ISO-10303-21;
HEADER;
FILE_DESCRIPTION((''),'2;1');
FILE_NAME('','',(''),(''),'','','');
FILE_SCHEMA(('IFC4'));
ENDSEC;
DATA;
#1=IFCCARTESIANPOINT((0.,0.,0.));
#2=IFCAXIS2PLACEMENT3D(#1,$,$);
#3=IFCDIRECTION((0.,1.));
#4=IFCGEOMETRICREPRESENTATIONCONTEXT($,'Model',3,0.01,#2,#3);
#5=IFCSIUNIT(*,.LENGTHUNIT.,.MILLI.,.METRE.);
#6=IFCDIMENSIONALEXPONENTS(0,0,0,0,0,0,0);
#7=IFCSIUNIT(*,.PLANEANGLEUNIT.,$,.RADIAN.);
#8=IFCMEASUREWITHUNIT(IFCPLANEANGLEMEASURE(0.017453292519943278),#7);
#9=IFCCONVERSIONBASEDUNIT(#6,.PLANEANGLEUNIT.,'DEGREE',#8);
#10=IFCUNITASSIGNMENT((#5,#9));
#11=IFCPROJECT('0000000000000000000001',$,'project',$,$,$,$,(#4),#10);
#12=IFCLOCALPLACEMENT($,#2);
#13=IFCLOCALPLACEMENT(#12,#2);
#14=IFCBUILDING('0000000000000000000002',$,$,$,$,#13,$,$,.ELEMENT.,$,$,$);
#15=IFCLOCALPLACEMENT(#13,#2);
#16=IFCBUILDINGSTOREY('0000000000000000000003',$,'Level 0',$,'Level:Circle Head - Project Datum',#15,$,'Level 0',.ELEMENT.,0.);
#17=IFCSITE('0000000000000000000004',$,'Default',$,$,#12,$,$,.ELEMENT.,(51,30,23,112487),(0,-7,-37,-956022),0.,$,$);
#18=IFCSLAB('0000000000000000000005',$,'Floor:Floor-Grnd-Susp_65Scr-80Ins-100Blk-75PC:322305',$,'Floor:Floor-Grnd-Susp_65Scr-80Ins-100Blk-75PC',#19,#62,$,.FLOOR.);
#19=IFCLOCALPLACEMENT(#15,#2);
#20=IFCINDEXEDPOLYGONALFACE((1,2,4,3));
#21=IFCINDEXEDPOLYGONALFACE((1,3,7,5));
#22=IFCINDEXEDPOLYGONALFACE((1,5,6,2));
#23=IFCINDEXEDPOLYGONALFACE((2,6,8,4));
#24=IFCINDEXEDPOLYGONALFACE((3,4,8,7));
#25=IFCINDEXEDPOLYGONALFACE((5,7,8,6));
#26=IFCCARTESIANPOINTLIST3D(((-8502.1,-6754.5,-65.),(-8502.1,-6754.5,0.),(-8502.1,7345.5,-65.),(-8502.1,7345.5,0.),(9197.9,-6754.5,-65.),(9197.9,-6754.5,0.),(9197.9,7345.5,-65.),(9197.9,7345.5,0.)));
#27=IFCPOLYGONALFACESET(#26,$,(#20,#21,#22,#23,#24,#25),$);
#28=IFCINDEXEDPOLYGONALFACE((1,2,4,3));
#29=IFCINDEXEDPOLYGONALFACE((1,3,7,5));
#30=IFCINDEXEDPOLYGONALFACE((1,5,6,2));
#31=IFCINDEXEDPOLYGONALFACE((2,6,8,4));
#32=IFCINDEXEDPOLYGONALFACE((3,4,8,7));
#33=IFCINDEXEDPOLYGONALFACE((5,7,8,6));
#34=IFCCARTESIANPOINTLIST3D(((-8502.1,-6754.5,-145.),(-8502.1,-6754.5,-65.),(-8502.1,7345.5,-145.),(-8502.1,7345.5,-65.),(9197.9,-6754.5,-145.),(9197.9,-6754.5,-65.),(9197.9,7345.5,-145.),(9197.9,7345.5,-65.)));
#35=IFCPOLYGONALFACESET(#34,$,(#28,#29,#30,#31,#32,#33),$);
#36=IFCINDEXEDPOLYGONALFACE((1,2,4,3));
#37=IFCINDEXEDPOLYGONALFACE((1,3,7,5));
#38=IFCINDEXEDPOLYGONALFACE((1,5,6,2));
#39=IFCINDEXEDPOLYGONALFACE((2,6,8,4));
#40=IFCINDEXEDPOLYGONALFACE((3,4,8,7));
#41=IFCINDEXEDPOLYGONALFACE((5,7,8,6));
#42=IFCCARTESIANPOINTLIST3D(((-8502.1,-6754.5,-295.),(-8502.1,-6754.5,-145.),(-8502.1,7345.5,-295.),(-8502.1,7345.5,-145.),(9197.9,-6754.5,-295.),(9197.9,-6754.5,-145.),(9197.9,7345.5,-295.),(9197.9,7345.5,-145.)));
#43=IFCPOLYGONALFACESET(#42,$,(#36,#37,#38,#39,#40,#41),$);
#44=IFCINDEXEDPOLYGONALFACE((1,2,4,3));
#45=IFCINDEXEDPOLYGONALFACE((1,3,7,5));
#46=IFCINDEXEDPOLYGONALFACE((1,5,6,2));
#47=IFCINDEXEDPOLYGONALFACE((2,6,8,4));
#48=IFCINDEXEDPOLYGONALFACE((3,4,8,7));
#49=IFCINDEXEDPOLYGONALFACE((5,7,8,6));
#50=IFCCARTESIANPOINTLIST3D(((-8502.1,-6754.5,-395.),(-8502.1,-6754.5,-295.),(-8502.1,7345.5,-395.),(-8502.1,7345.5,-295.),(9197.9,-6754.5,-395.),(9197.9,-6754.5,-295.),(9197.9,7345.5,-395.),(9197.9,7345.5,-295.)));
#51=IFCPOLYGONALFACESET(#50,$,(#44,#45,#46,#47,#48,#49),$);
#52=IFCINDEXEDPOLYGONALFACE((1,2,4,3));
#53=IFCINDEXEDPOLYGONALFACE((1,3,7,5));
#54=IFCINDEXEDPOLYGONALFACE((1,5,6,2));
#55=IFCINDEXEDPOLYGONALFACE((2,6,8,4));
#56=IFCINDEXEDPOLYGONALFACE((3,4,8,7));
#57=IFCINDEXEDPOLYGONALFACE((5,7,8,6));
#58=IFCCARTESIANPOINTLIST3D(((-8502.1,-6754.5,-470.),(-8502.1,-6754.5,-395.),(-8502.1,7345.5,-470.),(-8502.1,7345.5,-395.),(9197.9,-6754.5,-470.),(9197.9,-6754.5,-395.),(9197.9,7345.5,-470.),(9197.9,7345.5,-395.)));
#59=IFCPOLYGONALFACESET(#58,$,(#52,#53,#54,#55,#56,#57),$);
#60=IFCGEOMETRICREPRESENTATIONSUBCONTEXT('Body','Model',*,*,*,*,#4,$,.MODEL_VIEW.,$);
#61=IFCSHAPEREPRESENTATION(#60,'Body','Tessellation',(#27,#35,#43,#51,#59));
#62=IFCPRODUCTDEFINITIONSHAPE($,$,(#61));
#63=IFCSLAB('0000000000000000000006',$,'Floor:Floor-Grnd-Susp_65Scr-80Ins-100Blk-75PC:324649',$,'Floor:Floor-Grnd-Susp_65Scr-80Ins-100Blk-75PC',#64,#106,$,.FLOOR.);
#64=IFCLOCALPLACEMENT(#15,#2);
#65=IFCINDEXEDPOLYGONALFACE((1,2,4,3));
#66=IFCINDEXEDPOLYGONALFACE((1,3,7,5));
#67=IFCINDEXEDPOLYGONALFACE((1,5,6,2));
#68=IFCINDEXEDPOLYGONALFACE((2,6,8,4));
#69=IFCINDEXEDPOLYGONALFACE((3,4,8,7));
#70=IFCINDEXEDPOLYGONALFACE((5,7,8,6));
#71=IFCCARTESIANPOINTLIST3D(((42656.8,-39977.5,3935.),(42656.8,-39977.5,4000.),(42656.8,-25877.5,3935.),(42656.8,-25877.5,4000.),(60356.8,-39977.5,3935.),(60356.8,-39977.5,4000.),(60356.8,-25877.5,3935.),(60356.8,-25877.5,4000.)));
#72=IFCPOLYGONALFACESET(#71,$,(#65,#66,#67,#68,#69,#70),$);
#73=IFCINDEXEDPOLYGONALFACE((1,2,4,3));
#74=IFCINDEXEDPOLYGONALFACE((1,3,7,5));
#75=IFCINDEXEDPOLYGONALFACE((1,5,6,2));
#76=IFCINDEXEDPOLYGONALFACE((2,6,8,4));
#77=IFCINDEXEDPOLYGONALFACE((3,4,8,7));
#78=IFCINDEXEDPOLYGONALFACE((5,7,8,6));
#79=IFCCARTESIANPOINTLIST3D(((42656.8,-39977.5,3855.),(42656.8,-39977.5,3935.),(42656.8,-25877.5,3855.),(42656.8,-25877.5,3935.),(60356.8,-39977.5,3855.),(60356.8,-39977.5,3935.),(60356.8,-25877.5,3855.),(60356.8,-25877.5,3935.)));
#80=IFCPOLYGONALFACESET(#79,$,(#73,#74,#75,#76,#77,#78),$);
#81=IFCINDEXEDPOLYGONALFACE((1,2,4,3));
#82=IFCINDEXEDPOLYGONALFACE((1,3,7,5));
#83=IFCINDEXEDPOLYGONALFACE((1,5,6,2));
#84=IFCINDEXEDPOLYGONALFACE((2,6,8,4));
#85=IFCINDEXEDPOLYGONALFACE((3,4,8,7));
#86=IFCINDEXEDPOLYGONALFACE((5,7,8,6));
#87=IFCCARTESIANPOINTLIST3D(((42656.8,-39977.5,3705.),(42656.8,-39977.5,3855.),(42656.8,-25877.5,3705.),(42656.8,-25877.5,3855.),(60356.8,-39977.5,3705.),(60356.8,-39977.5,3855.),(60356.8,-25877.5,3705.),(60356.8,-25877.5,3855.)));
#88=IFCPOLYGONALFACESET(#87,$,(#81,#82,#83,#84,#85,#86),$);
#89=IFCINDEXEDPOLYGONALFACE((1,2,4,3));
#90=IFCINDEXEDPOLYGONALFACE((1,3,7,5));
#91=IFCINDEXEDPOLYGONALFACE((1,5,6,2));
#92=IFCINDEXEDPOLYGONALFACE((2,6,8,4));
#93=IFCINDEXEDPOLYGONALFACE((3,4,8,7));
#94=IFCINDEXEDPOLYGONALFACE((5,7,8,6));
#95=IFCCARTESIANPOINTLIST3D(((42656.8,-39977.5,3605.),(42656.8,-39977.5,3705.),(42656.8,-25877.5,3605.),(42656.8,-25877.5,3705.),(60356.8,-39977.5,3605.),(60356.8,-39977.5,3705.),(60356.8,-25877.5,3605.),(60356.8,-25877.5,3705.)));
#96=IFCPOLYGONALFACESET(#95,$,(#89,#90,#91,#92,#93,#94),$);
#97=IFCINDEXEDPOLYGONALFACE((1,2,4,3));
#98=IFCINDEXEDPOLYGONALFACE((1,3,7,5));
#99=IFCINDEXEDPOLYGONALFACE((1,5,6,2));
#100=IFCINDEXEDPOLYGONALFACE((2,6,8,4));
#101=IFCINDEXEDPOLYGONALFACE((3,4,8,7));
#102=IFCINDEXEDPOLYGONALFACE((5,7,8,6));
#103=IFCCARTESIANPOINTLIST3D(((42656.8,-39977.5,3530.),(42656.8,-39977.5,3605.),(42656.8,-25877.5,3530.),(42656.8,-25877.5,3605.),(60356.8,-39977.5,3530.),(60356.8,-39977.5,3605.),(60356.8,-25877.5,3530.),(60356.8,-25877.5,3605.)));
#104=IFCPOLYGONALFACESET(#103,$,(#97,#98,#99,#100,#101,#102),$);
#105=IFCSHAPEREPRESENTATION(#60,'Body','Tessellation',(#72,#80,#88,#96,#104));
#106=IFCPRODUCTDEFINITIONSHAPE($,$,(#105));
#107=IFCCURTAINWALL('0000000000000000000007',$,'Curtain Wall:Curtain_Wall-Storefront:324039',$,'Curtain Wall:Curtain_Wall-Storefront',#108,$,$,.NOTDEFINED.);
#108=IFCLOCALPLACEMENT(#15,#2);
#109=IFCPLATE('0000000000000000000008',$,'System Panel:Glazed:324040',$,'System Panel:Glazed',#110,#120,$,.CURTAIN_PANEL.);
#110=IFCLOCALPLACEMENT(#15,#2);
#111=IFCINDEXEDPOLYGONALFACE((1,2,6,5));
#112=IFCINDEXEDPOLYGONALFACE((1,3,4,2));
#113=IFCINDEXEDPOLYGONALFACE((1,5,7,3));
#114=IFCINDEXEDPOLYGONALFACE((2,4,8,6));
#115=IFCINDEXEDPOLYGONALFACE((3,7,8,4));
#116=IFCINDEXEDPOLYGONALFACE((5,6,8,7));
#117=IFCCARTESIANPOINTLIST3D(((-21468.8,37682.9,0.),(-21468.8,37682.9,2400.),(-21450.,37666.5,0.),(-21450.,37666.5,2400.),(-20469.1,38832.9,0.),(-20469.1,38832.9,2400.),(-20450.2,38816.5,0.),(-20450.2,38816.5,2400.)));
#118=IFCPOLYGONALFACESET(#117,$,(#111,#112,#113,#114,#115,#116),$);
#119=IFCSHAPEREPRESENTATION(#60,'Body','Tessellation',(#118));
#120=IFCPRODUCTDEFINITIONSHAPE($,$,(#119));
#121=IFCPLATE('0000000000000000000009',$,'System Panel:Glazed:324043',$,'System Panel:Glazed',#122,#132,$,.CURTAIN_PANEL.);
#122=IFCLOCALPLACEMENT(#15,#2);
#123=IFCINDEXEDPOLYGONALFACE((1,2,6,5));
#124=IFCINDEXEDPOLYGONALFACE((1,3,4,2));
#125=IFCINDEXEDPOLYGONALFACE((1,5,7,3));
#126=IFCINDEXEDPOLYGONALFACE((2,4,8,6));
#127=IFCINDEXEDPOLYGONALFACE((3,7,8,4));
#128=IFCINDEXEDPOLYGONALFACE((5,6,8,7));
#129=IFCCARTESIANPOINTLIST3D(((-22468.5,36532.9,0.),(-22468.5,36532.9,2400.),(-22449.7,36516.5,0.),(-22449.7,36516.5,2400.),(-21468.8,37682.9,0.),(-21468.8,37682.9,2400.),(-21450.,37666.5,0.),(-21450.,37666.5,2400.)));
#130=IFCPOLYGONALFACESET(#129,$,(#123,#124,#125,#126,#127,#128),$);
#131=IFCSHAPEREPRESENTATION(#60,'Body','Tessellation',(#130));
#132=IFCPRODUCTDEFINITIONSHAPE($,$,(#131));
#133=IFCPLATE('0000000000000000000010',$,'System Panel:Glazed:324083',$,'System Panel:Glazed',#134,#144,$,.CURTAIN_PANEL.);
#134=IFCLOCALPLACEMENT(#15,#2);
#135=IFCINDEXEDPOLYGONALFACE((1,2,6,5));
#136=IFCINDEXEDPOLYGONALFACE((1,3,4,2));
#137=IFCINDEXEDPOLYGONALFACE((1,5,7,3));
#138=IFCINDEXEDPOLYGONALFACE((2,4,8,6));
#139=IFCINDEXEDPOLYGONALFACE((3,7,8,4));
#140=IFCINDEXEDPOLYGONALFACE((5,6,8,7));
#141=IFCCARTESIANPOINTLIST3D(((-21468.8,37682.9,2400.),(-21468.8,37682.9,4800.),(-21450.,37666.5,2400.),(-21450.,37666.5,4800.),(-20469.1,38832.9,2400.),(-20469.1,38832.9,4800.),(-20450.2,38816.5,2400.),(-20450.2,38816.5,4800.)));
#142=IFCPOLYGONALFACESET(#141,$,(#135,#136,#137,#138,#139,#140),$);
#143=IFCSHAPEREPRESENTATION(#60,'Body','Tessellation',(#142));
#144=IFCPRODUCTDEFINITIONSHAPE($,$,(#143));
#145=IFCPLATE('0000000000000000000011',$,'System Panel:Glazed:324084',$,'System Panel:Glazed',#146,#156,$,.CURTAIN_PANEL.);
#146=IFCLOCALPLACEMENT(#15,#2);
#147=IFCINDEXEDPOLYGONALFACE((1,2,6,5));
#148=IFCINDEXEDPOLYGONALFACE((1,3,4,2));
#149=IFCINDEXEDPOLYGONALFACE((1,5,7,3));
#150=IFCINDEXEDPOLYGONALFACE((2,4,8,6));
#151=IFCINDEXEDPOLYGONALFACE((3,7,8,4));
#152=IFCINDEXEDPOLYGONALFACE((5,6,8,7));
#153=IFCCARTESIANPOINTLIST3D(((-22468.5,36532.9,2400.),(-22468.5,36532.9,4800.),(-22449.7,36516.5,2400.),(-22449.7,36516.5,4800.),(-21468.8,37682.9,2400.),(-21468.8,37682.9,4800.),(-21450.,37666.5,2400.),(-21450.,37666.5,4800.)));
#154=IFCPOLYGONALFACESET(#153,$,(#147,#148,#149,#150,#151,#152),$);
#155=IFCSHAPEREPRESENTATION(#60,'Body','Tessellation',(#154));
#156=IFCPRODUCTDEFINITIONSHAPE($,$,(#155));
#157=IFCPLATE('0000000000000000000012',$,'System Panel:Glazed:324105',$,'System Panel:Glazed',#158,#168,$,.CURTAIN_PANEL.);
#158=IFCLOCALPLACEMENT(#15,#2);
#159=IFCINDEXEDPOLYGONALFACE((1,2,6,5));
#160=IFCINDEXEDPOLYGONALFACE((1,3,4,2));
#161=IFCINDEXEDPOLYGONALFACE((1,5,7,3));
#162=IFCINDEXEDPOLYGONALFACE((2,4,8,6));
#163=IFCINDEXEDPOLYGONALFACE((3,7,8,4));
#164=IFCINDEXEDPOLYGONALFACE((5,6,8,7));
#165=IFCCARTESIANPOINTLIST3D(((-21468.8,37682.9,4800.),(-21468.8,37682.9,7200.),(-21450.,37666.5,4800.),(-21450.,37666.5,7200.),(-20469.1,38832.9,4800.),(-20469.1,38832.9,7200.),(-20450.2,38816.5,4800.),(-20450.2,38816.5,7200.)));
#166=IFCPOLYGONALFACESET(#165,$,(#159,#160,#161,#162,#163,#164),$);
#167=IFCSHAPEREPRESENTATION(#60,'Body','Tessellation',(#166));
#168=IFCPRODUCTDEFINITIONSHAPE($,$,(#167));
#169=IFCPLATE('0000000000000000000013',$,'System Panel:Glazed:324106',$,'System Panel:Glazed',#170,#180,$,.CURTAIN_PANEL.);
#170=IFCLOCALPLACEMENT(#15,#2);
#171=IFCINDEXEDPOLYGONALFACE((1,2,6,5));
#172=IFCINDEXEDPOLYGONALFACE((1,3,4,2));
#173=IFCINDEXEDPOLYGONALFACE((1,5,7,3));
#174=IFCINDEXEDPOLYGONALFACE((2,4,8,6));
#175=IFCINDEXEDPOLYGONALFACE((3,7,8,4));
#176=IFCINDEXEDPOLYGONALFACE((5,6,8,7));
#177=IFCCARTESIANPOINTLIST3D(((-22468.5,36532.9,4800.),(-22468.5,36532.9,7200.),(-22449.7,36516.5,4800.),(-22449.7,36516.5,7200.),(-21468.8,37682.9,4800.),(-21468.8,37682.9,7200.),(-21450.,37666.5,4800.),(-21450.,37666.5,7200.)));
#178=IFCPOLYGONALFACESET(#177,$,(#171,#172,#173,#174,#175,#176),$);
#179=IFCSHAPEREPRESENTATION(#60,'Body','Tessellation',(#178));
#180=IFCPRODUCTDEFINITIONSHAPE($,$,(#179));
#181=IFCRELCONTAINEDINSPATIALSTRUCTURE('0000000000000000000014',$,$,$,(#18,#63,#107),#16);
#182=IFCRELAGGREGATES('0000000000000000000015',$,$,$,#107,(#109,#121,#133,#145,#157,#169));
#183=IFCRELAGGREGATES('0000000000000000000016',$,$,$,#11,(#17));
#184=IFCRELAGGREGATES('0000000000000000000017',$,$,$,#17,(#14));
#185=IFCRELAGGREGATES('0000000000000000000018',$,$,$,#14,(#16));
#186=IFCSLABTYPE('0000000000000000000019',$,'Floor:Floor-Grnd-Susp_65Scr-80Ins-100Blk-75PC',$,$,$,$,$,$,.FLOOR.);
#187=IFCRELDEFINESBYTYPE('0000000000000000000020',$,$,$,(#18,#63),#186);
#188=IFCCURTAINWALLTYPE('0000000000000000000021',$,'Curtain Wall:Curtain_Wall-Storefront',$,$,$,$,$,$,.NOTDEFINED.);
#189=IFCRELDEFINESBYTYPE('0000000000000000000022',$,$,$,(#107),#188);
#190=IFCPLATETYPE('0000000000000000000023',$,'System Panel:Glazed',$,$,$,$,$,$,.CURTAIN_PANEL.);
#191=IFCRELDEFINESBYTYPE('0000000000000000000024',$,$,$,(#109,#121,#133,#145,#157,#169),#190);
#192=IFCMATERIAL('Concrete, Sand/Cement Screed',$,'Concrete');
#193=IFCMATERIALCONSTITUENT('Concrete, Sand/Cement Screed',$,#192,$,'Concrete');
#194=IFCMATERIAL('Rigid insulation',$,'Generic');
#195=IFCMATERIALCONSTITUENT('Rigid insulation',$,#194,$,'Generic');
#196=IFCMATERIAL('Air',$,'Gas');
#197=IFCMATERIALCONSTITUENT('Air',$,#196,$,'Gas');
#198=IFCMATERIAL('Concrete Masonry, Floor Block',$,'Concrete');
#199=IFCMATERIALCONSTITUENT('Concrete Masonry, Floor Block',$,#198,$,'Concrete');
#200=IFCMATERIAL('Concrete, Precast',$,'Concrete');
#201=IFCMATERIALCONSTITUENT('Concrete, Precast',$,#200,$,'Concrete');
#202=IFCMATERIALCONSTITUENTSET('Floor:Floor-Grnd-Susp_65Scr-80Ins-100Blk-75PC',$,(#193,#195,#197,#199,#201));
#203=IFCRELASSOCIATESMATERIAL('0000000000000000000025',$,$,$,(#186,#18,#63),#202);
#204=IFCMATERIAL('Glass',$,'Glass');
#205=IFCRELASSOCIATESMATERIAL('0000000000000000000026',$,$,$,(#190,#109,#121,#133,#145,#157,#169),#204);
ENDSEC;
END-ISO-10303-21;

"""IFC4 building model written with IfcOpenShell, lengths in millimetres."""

from ifc_helpers import new_model, entity, si_unit, converted_unit, direction, frame, origin, place, context, subcontext, project, spatial, indexed_curve, outline, extrude, source, transform, mapped, material, constituent, constituent_set, type_object, type_shapes, element, aggregate, save


model = new_model("IFC4")

# Units and contexts
model_context = context("Model", 3, precision=0.01, world=origin(), true_north=direction((0.0, 1.0)))
body_context = subcontext(model_context, "Body", "Model", "MODEL_VIEW")
ifc_project = project(units=[si_unit("LENGTHUNIT", "METRE", prefix="MILLI"), converted_unit("PLANEANGLEUNIT", "DEGREE", entity("IfcPlaneAngleMeasure", 0.017453292519943278), si_unit("PLANEANGLEUNIT", "RADIAN"), dimensions=[0, 0, 0, 0, 0, 0, 0])], contexts=[model_context])

# Site, building, storey
site_placement = place(None, origin())
site = spatial("IfcSite", under=ifc_project, at=site_placement, Name="Default", CompositionType="ELEMENT", RefLatitude=(51, 30, 23, 112487), RefLongitude=(0, -7, -37, -956022), RefElevation=0.0)
building_placement = place(site_placement, origin())
building = spatial("IfcBuilding", under=site, at=building_placement, CompositionType="ELEMENT")
storey_placement = place(building_placement, origin())
storey = spatial("IfcBuildingStorey", under=building, at=storey_placement, Name="Level 0", ObjectType="Level:Circle Head - Project Datum", LongName="Level 0", CompositionType="ELEMENT", Elevation=0.0)

# Slabs
ifc_material_1 = material(Name="Concrete, Sand/Cement Screed", Category="Concrete")
ifc_constituent_1 = constituent(ifc_material_1, Name="Concrete, Sand/Cement Screed", Category="Concrete")
ifc_material_2 = material(Name="Rigid insulation", Category="Generic")
ifc_constituent_2 = constituent(ifc_material_2, Name="Rigid insulation", Category="Generic")
ifc_material_3 = material(Name="Air", Category="Gas")
ifc_constituent_3 = constituent(ifc_material_3, Name="Air", Category="Gas")
ifc_material_4 = material(Name="Concrete Masonry, Floor Block", Category="Concrete")
ifc_constituent_4 = constituent(ifc_material_4, Name="Concrete Masonry, Floor Block", Category="Concrete")
ifc_material_5 = material(Name="Concrete, Precast", Category="Concrete")
ifc_constituent_5 = constituent(ifc_material_5, Name="Concrete, Precast", Category="Concrete")
ifc_constituent_set_1 = constituent_set(constituents=[ifc_constituent_1, ifc_constituent_2, ifc_constituent_3, ifc_constituent_4, ifc_constituent_5], Name="Floor:Floor-Grnd-Susp_65Scr-80Ins-100Blk-75PC")
slab_type = type_object("IfcSlabType", Name="Floor:Floor-Grnd-Susp_65Scr-80Ins-100Blk-75PC", PredefinedType="FLOOR", material=ifc_constituent_set_1)
slab_1_placement = place(storey_placement, origin())
element("IfcSlab", 1, at=slab_1_placement, inside=storey, type_object=slab_type, material=ifc_constituent_set_1, Name="Floor:Floor-Grnd-Susp_65Scr-80Ins-100Blk-75PC:322305", ObjectType="Floor:Floor-Grnd-Susp_65Scr-80Ins-100Blk-75PC", PredefinedType="FLOOR", context=body_context, shape_type="SweptSolid", body=[
    extrude(outline(indexed_curve([(-8850.0, -7050.0), (8850.0, -7050.0), (8850.0, 7050.0), (-8850.0, 7050.0), (-8850.0, -7050.0)], self_intersect=False)), frame((347.9, 295.5, -65.0), z_axis=(0.0, 0.0, 1.0), x_axis=(-1.0, 0.0, 0.0)), (0.0, 0.0, 1.0), 65.0),
    extrude(outline(indexed_curve([(-8850.0, -7050.0), (8850.0, -7050.0), (8850.0, 7050.0), (-8850.0, 7050.0), (-8850.0, -7050.0)], self_intersect=False)), frame((347.9, 295.5, -145.0), z_axis=(0.0, 0.0, 1.0), x_axis=(-1.0, 0.0, 0.0)), (0.0, 0.0, 1.0), 80.0),
    extrude(outline(indexed_curve([(-8850.0, -7050.0), (8850.0, -7050.0), (8850.0, 7050.0), (-8850.0, 7050.0), (-8850.0, -7050.0)], self_intersect=False)), frame((347.9, 295.5, -295.0), z_axis=(0.0, 0.0, 1.0), x_axis=(-1.0, 0.0, 0.0)), (0.0, 0.0, 1.0), 150.0),
    extrude(outline(indexed_curve([(-8850.0, -7050.0), (8850.0, -7050.0), (8850.0, 7050.0), (-8850.0, 7050.0), (-8850.0, -7050.0)], self_intersect=False)), frame((347.9, 295.5, -395.0), z_axis=(0.0, 0.0, 1.0), x_axis=(-1.0, 0.0, 0.0)), (0.0, 0.0, 1.0), 100.0),
    extrude(outline(indexed_curve([(-8850.0, -7050.0), (8850.0, -7050.0), (8850.0, 7050.0), (-8850.0, 7050.0), (-8850.0, -7050.0)], self_intersect=False)), frame((347.9, 295.5, -470.0), z_axis=(0.0, 0.0, 1.0), x_axis=(-1.0, 0.0, 0.0)), (0.0, 0.0, 1.0), 75.0),
])
slab_2_placement = place(storey_placement, origin())
element("IfcSlab", 2, at=slab_2_placement, inside=storey, type_object=slab_type, material=ifc_constituent_set_1, Name="Floor:Floor-Grnd-Susp_65Scr-80Ins-100Blk-75PC:324649", ObjectType="Floor:Floor-Grnd-Susp_65Scr-80Ins-100Blk-75PC", PredefinedType="FLOOR", context=body_context, shape_type="SweptSolid", body=[
    extrude(outline(indexed_curve([(-8850.0, -7050.0), (8850.0, -7050.0), (8850.0, 7050.0), (-8850.0, 7050.0), (-8850.0, -7050.0)], self_intersect=False)), frame((51506.8, -32927.5, 3935.0), z_axis=(0.0, 0.0, 1.0), x_axis=(-1.0, 0.0, 0.0)), (0.0, 0.0, 1.0), 65.0),
    extrude(outline(indexed_curve([(-8850.0, -7050.0), (8850.0, -7050.0), (8850.0, 7050.0), (-8850.0, 7050.0), (-8850.0, -7050.0)], self_intersect=False)), frame((51506.8, -32927.5, 3855.0), z_axis=(0.0, 0.0, 1.0), x_axis=(-1.0, 0.0, 0.0)), (0.0, 0.0, 1.0), 80.0),
    extrude(outline(indexed_curve([(-8850.0, -7050.0), (8850.0, -7050.0), (8850.0, 7050.0), (-8850.0, 7050.0), (-8850.0, -7050.0)], self_intersect=False)), frame((51506.8, -32927.5, 3705.0), z_axis=(0.0, 0.0, 1.0), x_axis=(-1.0, 0.0, 0.0)), (0.0, 0.0, 1.0), 150.0),
    extrude(outline(indexed_curve([(-8850.0, -7050.0), (8850.0, -7050.0), (8850.0, 7050.0), (-8850.0, 7050.0), (-8850.0, -7050.0)], self_intersect=False)), frame((51506.8, -32927.5, 3605.0), z_axis=(0.0, 0.0, 1.0), x_axis=(-1.0, 0.0, 0.0)), (0.0, 0.0, 1.0), 100.0),
    extrude(outline(indexed_curve([(-8850.0, -7050.0), (8850.0, -7050.0), (8850.0, 7050.0), (-8850.0, 7050.0), (-8850.0, -7050.0)], self_intersect=False)), frame((51506.8, -32927.5, 3530.0), z_axis=(0.0, 0.0, 1.0), x_axis=(-1.0, 0.0, 0.0)), (0.0, 0.0, 1.0), 75.0),
])

# Curtain wall, plates
curtain_wall_type = type_object("IfcCurtainWallType", Name="Curtain Wall:Curtain_Wall-Storefront", PredefinedType="NOTDEFINED")
curtain_wall_placement = place(storey_placement, origin())
curtain_wall = element("IfcCurtainWall", 3, at=curtain_wall_placement, inside=storey, type_object=curtain_wall_type, Name="Curtain Wall:Curtain_Wall-Storefront:324039", ObjectType="Curtain Wall:Curtain_Wall-Storefront", PredefinedType="NOTDEFINED")
ifc_material_6 = material(Name="Glass", Category="Glass")
plate_type_1 = type_object("IfcPlateType", Name="System Panel:Glazed", PredefinedType="CURTAIN_PANEL", material=ifc_material_6)
shared_shape_1 = source(origin(), body_context, "Body", "SweptSolid", [
    extrude(outline(indexed_curve([(-12.5, -761.9), (12.5, -761.9), (12.5, 761.9), (-12.5, 761.9), (-12.5, -761.9)], self_intersect=False)), frame((0.0, 37.0, 0.0), z_axis=(0.0, 0.0, 1.0), x_axis=(0.0, 1.0, 0.0)), (0.0, 0.0, 1.0), 2400.0),
])
type_shapes(plate_type_1, [shared_shape_1])
plate_1_placement = place(curtain_wall_placement, frame((-20987.5, 38274.0, 0.0), z_axis=(0.0, 0.0, 1.0), x_axis=(-0.656059, -0.75471, 0.0)))
plate_1 = element("IfcPlate", 4, at=plate_1_placement, type_object=plate_type_1, material=ifc_material_6, Name="System Panel:Glazed:324040", ObjectType="System Panel:Glazed", PredefinedType="CURTAIN_PANEL", context=body_context, shape_type="MappedRepresentation", body=[
    mapped(shared_shape_1, transform((0.0, 0.0, 0.0), scale=1.0)),
])
plate_2_placement = place(curtain_wall_placement, frame((-21987.2, 37124.0, 0.0), z_axis=(0.0, 0.0, 1.0), x_axis=(-0.656059, -0.75471, 0.0)))
plate_2 = element("IfcPlate", 5, at=plate_2_placement, type_object=plate_type_1, material=ifc_material_6, Name="System Panel:Glazed:324043", ObjectType="System Panel:Glazed", PredefinedType="CURTAIN_PANEL", context=body_context, shape_type="MappedRepresentation", body=[
    mapped(shared_shape_1, transform((0.0, 0.0, 0.0), scale=1.0)),
])
plate_3_placement = place(curtain_wall_placement, frame((-20987.5, 38274.0, 2400.0), z_axis=(0.0, 0.0, 1.0), x_axis=(-0.656059, -0.75471, 0.0)))
plate_3 = element("IfcPlate", 6, at=plate_3_placement, type_object=plate_type_1, material=ifc_material_6, Name="System Panel:Glazed:324083", ObjectType="System Panel:Glazed", PredefinedType="CURTAIN_PANEL", context=body_context, shape_type="MappedRepresentation", body=[
    mapped(shared_shape_1, transform((0.0, 0.0, 0.0), scale=1.0)),
])
plate_4_placement = place(curtain_wall_placement, frame((-21987.2, 37124.0, 2400.0), z_axis=(0.0, 0.0, 1.0), x_axis=(-0.656059, -0.75471, 0.0)))
plate_4 = element("IfcPlate", 7, at=plate_4_placement, type_object=plate_type_1, material=ifc_material_6, Name="System Panel:Glazed:324084", ObjectType="System Panel:Glazed", PredefinedType="CURTAIN_PANEL", context=body_context, shape_type="MappedRepresentation", body=[
    mapped(shared_shape_1, transform((0.0, 0.0, 0.0), scale=1.0)),
])
plate_5_placement = place(curtain_wall_placement, frame((-20987.5, 38274.0, 4800.0), z_axis=(0.0, 0.0, 1.0), x_axis=(-0.656059, -0.75471, 0.0)))
plate_5 = element("IfcPlate", 8, at=plate_5_placement, type_object=plate_type_1, material=ifc_material_6, Name="System Panel:Glazed:324105", ObjectType="System Panel:Glazed", PredefinedType="CURTAIN_PANEL", context=body_context, shape_type="MappedRepresentation", body=[
    mapped(shared_shape_1, transform((0.0, 0.0, 0.0), scale=1.0)),
])
plate_6_placement = place(curtain_wall_placement, frame((-21987.2, 37124.0, 4800.0), z_axis=(0.0, 0.0, 1.0), x_axis=(-0.656059, -0.75471, 0.0)))
plate_6 = element("IfcPlate", 9, at=plate_6_placement, type_object=plate_type_1, material=ifc_material_6, Name="System Panel:Glazed:324106", ObjectType="System Panel:Glazed", PredefinedType="CURTAIN_PANEL", context=body_context, shape_type="MappedRepresentation", body=[
    mapped(shared_shape_1, transform((0.0, 0.0, 0.0), scale=1.0)),
])
aggregate(curtain_wall, [plate_1, plate_2, plate_3, plate_4, plate_5, plate_6])

save(model, "model.ifc")
